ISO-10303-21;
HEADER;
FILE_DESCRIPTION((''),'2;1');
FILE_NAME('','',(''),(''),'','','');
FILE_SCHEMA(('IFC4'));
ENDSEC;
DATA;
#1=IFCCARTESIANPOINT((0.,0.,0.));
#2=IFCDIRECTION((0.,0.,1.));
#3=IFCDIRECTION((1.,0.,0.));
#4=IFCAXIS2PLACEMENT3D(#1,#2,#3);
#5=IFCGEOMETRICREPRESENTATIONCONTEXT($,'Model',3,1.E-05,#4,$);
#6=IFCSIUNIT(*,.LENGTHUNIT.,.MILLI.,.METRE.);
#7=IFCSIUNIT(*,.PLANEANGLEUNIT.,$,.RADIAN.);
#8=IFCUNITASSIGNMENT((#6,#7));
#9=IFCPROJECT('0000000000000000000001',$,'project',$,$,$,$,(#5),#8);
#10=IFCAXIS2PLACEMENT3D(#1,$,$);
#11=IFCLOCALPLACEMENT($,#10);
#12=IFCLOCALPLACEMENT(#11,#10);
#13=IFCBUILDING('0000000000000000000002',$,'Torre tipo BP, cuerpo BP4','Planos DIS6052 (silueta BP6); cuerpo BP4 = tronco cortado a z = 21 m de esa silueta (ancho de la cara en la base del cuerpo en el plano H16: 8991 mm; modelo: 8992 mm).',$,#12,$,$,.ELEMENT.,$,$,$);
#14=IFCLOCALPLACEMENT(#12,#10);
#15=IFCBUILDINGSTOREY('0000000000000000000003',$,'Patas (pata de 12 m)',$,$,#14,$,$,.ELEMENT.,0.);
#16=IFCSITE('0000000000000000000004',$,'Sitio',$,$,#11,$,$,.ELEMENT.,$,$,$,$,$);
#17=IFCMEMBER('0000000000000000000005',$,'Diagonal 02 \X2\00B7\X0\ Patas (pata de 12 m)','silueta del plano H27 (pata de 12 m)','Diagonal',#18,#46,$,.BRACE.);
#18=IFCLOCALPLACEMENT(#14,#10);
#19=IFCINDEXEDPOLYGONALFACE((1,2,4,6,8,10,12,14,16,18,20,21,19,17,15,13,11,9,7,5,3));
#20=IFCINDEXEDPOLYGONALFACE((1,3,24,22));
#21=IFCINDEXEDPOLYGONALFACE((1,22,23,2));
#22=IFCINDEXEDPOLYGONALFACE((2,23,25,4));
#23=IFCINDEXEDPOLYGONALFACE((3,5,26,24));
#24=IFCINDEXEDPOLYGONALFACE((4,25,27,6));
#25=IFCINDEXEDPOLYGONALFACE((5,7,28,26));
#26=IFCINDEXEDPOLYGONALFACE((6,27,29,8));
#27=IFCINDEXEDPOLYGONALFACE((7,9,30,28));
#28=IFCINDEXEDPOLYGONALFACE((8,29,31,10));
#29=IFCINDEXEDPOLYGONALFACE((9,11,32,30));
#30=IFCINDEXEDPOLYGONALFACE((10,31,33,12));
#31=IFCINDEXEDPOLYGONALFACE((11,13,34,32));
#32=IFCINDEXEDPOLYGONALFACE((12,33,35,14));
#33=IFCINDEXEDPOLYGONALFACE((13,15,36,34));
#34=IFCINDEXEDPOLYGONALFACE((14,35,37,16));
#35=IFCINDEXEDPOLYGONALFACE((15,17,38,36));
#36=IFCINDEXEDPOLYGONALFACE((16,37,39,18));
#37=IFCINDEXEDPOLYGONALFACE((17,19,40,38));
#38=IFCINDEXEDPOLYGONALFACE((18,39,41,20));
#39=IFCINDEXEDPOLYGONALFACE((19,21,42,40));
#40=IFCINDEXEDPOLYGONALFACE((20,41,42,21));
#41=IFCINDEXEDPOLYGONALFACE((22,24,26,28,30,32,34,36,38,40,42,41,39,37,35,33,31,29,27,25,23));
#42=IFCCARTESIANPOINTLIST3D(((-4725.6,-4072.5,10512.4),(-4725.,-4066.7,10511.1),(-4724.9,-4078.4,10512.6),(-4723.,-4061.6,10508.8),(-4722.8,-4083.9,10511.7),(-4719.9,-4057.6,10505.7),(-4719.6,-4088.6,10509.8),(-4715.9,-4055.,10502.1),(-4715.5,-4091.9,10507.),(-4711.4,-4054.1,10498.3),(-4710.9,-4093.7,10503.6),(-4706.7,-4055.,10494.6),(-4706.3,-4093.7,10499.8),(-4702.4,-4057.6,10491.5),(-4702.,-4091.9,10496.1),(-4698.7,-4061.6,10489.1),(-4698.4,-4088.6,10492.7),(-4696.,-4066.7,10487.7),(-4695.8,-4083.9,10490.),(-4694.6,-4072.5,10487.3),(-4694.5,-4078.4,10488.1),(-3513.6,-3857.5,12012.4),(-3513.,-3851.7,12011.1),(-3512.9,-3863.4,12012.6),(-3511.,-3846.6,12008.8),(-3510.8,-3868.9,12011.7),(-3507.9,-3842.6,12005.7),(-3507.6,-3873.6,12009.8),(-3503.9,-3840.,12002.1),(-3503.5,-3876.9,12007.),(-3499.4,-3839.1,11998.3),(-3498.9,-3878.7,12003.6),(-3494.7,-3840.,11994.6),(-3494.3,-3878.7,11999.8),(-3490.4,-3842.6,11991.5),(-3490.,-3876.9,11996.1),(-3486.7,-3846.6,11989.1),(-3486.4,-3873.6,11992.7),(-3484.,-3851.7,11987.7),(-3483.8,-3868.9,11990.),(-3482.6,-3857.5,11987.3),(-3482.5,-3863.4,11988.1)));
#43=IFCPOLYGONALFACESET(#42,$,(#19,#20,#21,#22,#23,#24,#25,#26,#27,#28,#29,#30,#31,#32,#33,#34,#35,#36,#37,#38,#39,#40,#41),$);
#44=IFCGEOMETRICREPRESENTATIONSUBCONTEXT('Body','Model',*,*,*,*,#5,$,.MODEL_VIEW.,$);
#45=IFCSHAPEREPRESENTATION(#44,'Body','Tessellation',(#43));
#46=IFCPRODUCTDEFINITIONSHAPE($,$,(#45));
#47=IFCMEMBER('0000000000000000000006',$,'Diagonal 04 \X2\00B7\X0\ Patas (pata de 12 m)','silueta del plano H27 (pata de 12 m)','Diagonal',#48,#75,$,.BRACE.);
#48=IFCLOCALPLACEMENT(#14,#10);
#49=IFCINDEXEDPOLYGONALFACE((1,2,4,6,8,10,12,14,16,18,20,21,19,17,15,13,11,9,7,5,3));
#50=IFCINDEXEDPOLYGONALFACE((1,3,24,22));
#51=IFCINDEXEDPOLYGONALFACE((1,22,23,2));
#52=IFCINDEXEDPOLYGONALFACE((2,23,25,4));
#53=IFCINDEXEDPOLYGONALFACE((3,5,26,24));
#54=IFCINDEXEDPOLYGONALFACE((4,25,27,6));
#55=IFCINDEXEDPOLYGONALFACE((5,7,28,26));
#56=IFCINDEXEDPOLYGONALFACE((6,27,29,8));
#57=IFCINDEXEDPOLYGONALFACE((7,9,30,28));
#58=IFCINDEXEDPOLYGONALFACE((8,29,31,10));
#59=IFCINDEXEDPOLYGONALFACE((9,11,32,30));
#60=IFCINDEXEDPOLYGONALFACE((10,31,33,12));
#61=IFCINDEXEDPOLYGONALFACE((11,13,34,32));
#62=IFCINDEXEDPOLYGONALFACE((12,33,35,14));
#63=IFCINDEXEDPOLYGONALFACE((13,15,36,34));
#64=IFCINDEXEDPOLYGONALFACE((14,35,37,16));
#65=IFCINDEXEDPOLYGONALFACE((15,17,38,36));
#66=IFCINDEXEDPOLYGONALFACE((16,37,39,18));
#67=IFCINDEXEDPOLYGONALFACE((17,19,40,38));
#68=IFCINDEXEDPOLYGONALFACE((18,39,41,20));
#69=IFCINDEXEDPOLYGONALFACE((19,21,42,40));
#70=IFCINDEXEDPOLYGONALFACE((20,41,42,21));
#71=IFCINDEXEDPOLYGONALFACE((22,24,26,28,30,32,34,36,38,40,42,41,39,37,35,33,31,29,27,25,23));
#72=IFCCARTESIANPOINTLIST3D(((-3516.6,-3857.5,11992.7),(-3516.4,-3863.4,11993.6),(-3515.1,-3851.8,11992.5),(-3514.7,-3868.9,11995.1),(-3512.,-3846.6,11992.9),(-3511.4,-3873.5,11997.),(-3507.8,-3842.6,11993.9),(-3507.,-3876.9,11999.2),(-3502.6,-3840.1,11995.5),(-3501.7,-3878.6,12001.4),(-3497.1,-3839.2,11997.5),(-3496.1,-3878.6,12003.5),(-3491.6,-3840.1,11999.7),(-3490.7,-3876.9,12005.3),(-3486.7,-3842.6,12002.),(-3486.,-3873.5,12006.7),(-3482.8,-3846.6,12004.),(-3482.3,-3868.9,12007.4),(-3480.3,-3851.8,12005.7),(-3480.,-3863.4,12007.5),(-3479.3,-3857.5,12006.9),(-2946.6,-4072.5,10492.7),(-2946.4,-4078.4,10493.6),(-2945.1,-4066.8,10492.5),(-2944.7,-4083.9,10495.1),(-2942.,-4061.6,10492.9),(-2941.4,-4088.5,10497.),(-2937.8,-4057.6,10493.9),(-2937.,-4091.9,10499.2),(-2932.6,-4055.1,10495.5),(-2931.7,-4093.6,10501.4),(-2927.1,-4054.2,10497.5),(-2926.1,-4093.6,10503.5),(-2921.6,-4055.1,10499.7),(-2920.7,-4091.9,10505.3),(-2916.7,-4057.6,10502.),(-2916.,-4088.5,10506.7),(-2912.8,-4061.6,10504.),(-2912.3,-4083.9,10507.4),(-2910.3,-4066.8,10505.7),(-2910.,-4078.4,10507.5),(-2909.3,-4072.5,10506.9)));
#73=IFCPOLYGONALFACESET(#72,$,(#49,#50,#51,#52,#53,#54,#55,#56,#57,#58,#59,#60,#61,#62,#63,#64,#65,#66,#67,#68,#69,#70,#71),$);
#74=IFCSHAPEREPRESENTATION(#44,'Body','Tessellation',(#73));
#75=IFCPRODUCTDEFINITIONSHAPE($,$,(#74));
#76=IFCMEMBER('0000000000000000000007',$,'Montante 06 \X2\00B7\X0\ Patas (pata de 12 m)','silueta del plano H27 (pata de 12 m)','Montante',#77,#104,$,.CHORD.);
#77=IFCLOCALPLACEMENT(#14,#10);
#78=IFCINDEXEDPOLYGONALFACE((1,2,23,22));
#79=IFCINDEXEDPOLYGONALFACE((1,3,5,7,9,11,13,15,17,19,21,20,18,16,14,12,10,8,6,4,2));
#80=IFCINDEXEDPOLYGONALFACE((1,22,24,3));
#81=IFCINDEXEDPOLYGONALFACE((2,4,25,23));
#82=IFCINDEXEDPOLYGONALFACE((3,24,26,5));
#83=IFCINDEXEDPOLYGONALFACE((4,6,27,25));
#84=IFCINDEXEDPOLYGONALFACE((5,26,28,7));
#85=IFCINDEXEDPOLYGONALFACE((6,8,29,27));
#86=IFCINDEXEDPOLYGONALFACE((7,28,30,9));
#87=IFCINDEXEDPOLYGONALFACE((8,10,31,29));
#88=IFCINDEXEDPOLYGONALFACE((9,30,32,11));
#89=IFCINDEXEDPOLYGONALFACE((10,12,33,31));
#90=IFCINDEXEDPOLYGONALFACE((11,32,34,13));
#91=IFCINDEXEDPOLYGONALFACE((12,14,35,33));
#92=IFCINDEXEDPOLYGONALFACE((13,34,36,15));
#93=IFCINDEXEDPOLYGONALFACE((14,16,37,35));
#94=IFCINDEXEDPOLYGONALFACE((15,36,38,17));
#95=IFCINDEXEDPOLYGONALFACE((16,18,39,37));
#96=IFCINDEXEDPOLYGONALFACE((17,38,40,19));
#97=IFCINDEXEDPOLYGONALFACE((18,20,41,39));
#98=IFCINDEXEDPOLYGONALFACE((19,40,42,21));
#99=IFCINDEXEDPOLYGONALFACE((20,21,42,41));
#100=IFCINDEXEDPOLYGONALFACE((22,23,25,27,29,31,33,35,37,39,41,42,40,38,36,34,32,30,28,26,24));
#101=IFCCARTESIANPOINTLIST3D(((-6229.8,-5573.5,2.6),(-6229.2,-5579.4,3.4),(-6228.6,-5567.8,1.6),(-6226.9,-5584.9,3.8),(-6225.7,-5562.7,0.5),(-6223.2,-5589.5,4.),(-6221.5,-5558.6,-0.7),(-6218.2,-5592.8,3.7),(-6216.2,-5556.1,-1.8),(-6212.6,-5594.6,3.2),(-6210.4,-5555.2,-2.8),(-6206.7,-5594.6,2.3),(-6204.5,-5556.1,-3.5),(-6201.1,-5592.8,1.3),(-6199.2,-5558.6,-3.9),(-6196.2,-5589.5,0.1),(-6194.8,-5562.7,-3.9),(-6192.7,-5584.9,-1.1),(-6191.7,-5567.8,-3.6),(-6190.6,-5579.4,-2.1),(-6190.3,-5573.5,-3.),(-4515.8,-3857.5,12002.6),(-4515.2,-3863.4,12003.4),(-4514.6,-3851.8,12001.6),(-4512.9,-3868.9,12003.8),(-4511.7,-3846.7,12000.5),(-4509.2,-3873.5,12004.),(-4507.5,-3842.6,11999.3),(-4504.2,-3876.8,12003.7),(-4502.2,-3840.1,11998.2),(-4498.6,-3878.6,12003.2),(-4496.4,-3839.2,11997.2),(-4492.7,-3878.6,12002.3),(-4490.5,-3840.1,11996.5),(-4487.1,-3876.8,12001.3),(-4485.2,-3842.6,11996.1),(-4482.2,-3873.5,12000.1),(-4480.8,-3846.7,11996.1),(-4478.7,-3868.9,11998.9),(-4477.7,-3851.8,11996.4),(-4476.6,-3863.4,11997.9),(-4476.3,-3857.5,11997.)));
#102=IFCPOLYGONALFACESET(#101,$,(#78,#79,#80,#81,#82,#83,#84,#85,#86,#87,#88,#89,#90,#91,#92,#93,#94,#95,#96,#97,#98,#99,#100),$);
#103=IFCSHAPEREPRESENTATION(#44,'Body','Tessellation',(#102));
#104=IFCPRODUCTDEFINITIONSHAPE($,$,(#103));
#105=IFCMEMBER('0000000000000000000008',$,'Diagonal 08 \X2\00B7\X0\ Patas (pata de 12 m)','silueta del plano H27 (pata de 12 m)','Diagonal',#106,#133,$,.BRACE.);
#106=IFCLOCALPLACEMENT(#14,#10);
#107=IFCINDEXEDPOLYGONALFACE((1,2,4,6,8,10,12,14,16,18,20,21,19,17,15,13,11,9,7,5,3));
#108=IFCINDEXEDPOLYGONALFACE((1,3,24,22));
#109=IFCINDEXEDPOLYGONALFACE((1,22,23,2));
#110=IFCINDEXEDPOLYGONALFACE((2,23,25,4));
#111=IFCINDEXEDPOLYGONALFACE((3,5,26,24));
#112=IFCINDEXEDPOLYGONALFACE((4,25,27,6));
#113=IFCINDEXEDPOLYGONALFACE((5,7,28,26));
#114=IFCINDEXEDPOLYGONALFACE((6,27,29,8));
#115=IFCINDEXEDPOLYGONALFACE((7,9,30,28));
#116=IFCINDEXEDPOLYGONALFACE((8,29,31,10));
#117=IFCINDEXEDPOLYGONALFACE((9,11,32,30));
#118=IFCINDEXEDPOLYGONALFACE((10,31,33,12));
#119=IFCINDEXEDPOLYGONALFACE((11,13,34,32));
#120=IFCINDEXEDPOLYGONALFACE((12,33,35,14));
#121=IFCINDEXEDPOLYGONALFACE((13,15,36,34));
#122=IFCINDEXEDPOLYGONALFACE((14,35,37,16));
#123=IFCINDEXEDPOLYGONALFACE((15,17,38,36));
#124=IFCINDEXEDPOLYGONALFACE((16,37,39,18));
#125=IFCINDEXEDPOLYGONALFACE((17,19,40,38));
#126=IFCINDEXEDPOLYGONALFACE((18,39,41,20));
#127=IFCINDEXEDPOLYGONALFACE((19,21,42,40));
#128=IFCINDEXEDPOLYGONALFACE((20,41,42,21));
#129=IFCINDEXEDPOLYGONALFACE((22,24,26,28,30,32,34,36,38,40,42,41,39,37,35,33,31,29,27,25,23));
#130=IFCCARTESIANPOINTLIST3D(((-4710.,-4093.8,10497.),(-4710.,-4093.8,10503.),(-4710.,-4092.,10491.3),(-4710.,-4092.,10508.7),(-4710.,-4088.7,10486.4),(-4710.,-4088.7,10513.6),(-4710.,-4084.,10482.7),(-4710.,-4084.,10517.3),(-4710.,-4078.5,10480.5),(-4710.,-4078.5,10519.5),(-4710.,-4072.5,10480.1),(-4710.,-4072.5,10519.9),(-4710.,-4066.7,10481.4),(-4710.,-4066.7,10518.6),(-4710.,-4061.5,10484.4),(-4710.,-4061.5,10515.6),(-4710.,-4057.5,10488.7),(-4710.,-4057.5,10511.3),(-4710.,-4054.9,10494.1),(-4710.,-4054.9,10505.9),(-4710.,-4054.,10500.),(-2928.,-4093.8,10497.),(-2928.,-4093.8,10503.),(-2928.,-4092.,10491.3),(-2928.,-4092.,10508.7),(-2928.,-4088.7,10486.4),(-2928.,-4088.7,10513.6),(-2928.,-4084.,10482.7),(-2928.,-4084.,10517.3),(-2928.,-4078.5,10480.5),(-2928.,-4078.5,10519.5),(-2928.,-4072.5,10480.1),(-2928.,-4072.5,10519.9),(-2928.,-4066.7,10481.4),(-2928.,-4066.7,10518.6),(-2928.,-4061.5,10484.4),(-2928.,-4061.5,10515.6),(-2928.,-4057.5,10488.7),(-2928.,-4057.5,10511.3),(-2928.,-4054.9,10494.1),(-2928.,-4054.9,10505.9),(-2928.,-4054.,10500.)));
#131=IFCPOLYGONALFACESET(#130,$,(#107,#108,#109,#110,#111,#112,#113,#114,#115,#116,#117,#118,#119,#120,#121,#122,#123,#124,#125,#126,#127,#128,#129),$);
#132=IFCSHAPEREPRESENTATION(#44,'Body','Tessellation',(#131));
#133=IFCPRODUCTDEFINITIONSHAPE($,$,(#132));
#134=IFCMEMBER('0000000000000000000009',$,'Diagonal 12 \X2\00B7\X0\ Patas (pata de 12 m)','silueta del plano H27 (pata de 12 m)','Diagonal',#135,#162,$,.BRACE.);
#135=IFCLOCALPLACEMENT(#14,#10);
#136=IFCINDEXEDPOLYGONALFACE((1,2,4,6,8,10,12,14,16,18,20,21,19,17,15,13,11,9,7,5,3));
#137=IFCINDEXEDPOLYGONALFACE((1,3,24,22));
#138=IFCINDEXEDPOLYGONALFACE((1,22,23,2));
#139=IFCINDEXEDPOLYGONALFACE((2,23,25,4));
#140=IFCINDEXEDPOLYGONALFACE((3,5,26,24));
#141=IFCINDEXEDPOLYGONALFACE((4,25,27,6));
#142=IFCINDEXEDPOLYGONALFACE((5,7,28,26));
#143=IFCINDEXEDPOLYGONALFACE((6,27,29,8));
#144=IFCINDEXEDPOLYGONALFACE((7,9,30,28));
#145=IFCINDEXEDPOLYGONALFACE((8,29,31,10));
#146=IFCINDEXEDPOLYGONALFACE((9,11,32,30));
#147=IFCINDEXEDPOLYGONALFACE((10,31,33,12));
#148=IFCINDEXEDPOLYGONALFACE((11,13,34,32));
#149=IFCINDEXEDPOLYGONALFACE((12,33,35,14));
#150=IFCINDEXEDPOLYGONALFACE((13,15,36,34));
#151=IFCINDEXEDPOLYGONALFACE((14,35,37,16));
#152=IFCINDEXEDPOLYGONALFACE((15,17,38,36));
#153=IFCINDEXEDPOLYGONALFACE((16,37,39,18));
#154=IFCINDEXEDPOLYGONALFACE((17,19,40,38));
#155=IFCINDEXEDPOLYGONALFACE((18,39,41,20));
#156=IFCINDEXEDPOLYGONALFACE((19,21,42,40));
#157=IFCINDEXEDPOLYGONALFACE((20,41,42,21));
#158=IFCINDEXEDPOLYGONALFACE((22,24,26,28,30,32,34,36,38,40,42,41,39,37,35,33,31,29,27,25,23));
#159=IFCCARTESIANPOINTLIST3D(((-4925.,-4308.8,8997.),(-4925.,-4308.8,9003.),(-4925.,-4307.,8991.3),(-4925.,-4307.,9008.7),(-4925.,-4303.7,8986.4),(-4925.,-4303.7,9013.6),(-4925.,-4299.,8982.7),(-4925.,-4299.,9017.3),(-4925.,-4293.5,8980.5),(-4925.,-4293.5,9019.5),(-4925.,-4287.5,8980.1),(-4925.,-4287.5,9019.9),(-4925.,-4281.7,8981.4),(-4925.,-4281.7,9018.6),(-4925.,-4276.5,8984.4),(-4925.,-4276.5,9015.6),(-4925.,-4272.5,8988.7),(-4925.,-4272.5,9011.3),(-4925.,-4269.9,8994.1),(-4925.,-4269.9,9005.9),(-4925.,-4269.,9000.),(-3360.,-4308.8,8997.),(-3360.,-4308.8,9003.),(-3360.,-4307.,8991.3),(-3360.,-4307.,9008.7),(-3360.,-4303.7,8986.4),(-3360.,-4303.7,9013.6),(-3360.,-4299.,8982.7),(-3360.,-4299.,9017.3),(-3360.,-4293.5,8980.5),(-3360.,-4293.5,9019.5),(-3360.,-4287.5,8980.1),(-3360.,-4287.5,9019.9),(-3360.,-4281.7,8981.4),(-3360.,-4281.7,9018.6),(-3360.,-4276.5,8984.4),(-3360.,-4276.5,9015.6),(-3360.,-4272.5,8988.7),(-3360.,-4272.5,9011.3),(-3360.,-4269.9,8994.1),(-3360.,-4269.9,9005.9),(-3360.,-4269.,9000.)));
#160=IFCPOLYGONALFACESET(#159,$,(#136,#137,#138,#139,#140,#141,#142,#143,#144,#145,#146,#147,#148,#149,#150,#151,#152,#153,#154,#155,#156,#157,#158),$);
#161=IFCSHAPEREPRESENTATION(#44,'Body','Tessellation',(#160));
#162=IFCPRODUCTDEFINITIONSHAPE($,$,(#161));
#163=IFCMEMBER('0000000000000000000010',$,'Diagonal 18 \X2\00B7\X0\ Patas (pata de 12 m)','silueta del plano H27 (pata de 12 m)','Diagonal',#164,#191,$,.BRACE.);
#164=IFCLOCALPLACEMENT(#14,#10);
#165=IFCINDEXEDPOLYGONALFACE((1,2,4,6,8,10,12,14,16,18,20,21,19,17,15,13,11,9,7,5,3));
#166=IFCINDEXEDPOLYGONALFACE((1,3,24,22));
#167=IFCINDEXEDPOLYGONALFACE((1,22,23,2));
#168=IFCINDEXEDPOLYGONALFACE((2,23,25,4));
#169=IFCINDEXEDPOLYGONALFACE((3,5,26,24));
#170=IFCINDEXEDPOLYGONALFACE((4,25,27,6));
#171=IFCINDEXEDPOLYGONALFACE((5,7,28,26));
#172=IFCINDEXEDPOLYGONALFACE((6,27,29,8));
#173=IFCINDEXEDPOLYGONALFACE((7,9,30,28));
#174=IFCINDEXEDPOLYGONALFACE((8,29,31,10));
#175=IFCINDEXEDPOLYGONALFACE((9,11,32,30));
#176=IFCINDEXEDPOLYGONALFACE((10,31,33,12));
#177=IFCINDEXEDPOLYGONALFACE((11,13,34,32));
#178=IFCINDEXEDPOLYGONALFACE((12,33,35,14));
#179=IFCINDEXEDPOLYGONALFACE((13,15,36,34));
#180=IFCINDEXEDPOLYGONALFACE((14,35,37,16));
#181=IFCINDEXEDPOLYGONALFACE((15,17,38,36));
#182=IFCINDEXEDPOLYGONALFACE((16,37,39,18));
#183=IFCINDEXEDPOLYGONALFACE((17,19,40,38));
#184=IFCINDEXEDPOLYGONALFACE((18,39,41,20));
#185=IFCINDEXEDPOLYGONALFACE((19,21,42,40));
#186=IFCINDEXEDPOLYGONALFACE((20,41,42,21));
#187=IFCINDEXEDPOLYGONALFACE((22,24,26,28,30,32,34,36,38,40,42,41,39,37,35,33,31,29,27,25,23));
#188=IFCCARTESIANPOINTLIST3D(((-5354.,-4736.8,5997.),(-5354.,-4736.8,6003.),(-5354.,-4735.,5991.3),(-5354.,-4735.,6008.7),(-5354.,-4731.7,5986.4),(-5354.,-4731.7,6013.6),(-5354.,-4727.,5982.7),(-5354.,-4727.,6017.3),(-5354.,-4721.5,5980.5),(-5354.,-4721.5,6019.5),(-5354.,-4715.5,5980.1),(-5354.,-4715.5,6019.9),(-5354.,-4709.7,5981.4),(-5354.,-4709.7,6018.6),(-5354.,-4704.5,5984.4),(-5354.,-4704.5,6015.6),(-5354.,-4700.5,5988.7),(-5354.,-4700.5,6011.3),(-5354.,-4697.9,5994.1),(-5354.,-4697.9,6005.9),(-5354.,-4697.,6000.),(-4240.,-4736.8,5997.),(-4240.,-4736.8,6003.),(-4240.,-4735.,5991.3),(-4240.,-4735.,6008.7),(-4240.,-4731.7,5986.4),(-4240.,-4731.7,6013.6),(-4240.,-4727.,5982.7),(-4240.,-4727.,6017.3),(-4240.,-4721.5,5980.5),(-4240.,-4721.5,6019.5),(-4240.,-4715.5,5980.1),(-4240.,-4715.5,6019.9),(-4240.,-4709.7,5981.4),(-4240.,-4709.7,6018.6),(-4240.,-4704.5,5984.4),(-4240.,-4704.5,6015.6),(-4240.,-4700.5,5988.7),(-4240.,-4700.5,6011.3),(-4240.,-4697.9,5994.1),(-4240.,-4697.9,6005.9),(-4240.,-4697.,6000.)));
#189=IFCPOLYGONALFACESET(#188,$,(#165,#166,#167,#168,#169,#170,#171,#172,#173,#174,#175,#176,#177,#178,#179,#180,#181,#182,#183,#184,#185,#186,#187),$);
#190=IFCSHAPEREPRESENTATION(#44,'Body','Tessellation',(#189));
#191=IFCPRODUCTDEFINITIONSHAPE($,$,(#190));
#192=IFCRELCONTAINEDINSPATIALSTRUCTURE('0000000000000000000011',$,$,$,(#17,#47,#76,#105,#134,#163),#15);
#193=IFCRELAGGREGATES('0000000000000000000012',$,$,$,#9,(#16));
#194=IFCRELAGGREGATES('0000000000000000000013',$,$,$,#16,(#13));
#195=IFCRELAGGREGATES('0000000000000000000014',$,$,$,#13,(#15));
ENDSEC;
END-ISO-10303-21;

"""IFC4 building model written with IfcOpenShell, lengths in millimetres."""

from ifc_helpers import new_model, si_unit, frame, origin, origin_with_axes, place, context, subcontext, project, spatial, circle, extrude, element, save


model = new_model("IFC4")

# Units and contexts
model_context = context("Model", 3, precision=1e-05, world=origin_with_axes())
body_context = subcontext(model_context, "Body", "Model", "MODEL_VIEW")
ifc_project = project(units=[si_unit("LENGTHUNIT", "METRE", prefix="MILLI"), si_unit("PLANEANGLEUNIT", "RADIAN")], contexts=[model_context])

# Site, building, storey
site_placement = place(None, origin())
site = spatial("IfcSite", under=ifc_project, at=site_placement, Name="Sitio", CompositionType="ELEMENT")
building_placement = place(site_placement, origin())
building = spatial("IfcBuilding", under=site, at=building_placement, Name="Torre tipo BP, cuerpo BP4", Description="Planos DIS6052 (silueta BP6); cuerpo BP4 = tronco cortado a z = 21 m de esa silueta (ancho de la cara en la base del cuerpo en el plano H16: 8991 mm; modelo: 8992 mm).", CompositionType="ELEMENT")
storey_placement = place(building_placement, origin())
storey = spatial("IfcBuildingStorey", under=building, at=storey_placement, Name="Patas (pata de 12 m)", CompositionType="ELEMENT", Elevation=0.0)

# Members
member_1_placement = place(storey_placement, frame((-4710.0, -4074.0, 10500.0), z_axis=(0.624612, 0.110802, 0.773035), x_axis=(-0.069637, 0.993843, -0.086184)))
element("IfcMember", 1, at=member_1_placement, inside=storey, Name="Diagonal 02 · Patas (pata de 12 m)", Description="silueta del plano H27 (pata de 12 m)", ObjectType="Diagonal", PredefinedType="BRACE", context=body_context, shape_type="SweptSolid", body=[
    extrude(circle(Radius=20.0), None, (0.0, 0.0, 1.0), 1940.4),
])
member_2_placement = place(storey_placement, frame((-3498.0, -3859.0, 12000.0), z_axis=(0.352072, -0.132799, -0.926504), x_axis=(0.047173, 0.991143, -0.124138)))
element("IfcMember", 2, at=member_2_placement, inside=storey, Name="Diagonal 04 · Patas (pata de 12 m)", Description="silueta del plano H27 (pata de 12 m)", ObjectType="Diagonal", PredefinedType="BRACE", context=body_context, shape_type="SweptSolid", body=[
    extrude(circle(Radius=20.0), None, (0.0, 0.0, 1.0), 1619.0),
])
member_3_placement = place(storey_placement, frame((-4496.0, -3859.0, 12000.0), z_axis=(-0.140002, -0.140166, -0.98018), x_axis=(-0.019819, 0.990128, -0.138757)))
element("IfcMember", 3, at=member_3_placement, inside=storey, Name="Montante 06 · Patas (pata de 12 m)", Description="silueta del plano H27 (pata de 12 m)", ObjectType="Montante", PredefinedType="CHORD", context=body_context, shape_type="SweptSolid", body=[
    extrude(circle(Radius=20.0), None, (0.0, 0.0, 1.0), 12242.6),
])
member_4_placement = place(storey_placement, frame((-2928.0, -4074.0, 10500.0), z_axis=(-1.0, 0.0, 0.0), x_axis=(0.0, 1.0, 0.0)))
element("IfcMember", 4, at=member_4_placement, inside=storey, Name="Diagonal 08 · Patas (pata de 12 m)", Description="silueta del plano H27 (pata de 12 m)", ObjectType="Diagonal", PredefinedType="BRACE", context=body_context, shape_type="SweptSolid", body=[
    extrude(circle(Radius=20.0), None, (0.0, 0.0, 1.0), 1782.0),
])
member_5_placement = place(storey_placement, frame((-4925.0, -4289.0, 9000.0), z_axis=(1.0, 0.0, 0.0), x_axis=(0.0, 1.0, 0.0)))
element("IfcMember", 5, at=member_5_placement, inside=storey, Name="Diagonal 12 · Patas (pata de 12 m)", Description="silueta del plano H27 (pata de 12 m)", ObjectType="Diagonal", PredefinedType="BRACE", context=body_context, shape_type="SweptSolid", body=[
    extrude(circle(Radius=20.0), None, (0.0, 0.0, 1.0), 1565.0),
])
member_6_placement = place(storey_placement, frame((-5354.0, -4717.0, 6000.0), z_axis=(1.0, 0.0, 0.0), x_axis=(0.0, 1.0, 0.0)))
element("IfcMember", 6, at=member_6_placement, inside=storey, Name="Diagonal 18 · Patas (pata de 12 m)", Description="silueta del plano H27 (pata de 12 m)", ObjectType="Diagonal", PredefinedType="BRACE", context=body_context, shape_type="SweptSolid", body=[
    extrude(circle(Radius=20.0), None, (0.0, 0.0, 1.0), 1114.0),
])

save(model, "model.ifc")
